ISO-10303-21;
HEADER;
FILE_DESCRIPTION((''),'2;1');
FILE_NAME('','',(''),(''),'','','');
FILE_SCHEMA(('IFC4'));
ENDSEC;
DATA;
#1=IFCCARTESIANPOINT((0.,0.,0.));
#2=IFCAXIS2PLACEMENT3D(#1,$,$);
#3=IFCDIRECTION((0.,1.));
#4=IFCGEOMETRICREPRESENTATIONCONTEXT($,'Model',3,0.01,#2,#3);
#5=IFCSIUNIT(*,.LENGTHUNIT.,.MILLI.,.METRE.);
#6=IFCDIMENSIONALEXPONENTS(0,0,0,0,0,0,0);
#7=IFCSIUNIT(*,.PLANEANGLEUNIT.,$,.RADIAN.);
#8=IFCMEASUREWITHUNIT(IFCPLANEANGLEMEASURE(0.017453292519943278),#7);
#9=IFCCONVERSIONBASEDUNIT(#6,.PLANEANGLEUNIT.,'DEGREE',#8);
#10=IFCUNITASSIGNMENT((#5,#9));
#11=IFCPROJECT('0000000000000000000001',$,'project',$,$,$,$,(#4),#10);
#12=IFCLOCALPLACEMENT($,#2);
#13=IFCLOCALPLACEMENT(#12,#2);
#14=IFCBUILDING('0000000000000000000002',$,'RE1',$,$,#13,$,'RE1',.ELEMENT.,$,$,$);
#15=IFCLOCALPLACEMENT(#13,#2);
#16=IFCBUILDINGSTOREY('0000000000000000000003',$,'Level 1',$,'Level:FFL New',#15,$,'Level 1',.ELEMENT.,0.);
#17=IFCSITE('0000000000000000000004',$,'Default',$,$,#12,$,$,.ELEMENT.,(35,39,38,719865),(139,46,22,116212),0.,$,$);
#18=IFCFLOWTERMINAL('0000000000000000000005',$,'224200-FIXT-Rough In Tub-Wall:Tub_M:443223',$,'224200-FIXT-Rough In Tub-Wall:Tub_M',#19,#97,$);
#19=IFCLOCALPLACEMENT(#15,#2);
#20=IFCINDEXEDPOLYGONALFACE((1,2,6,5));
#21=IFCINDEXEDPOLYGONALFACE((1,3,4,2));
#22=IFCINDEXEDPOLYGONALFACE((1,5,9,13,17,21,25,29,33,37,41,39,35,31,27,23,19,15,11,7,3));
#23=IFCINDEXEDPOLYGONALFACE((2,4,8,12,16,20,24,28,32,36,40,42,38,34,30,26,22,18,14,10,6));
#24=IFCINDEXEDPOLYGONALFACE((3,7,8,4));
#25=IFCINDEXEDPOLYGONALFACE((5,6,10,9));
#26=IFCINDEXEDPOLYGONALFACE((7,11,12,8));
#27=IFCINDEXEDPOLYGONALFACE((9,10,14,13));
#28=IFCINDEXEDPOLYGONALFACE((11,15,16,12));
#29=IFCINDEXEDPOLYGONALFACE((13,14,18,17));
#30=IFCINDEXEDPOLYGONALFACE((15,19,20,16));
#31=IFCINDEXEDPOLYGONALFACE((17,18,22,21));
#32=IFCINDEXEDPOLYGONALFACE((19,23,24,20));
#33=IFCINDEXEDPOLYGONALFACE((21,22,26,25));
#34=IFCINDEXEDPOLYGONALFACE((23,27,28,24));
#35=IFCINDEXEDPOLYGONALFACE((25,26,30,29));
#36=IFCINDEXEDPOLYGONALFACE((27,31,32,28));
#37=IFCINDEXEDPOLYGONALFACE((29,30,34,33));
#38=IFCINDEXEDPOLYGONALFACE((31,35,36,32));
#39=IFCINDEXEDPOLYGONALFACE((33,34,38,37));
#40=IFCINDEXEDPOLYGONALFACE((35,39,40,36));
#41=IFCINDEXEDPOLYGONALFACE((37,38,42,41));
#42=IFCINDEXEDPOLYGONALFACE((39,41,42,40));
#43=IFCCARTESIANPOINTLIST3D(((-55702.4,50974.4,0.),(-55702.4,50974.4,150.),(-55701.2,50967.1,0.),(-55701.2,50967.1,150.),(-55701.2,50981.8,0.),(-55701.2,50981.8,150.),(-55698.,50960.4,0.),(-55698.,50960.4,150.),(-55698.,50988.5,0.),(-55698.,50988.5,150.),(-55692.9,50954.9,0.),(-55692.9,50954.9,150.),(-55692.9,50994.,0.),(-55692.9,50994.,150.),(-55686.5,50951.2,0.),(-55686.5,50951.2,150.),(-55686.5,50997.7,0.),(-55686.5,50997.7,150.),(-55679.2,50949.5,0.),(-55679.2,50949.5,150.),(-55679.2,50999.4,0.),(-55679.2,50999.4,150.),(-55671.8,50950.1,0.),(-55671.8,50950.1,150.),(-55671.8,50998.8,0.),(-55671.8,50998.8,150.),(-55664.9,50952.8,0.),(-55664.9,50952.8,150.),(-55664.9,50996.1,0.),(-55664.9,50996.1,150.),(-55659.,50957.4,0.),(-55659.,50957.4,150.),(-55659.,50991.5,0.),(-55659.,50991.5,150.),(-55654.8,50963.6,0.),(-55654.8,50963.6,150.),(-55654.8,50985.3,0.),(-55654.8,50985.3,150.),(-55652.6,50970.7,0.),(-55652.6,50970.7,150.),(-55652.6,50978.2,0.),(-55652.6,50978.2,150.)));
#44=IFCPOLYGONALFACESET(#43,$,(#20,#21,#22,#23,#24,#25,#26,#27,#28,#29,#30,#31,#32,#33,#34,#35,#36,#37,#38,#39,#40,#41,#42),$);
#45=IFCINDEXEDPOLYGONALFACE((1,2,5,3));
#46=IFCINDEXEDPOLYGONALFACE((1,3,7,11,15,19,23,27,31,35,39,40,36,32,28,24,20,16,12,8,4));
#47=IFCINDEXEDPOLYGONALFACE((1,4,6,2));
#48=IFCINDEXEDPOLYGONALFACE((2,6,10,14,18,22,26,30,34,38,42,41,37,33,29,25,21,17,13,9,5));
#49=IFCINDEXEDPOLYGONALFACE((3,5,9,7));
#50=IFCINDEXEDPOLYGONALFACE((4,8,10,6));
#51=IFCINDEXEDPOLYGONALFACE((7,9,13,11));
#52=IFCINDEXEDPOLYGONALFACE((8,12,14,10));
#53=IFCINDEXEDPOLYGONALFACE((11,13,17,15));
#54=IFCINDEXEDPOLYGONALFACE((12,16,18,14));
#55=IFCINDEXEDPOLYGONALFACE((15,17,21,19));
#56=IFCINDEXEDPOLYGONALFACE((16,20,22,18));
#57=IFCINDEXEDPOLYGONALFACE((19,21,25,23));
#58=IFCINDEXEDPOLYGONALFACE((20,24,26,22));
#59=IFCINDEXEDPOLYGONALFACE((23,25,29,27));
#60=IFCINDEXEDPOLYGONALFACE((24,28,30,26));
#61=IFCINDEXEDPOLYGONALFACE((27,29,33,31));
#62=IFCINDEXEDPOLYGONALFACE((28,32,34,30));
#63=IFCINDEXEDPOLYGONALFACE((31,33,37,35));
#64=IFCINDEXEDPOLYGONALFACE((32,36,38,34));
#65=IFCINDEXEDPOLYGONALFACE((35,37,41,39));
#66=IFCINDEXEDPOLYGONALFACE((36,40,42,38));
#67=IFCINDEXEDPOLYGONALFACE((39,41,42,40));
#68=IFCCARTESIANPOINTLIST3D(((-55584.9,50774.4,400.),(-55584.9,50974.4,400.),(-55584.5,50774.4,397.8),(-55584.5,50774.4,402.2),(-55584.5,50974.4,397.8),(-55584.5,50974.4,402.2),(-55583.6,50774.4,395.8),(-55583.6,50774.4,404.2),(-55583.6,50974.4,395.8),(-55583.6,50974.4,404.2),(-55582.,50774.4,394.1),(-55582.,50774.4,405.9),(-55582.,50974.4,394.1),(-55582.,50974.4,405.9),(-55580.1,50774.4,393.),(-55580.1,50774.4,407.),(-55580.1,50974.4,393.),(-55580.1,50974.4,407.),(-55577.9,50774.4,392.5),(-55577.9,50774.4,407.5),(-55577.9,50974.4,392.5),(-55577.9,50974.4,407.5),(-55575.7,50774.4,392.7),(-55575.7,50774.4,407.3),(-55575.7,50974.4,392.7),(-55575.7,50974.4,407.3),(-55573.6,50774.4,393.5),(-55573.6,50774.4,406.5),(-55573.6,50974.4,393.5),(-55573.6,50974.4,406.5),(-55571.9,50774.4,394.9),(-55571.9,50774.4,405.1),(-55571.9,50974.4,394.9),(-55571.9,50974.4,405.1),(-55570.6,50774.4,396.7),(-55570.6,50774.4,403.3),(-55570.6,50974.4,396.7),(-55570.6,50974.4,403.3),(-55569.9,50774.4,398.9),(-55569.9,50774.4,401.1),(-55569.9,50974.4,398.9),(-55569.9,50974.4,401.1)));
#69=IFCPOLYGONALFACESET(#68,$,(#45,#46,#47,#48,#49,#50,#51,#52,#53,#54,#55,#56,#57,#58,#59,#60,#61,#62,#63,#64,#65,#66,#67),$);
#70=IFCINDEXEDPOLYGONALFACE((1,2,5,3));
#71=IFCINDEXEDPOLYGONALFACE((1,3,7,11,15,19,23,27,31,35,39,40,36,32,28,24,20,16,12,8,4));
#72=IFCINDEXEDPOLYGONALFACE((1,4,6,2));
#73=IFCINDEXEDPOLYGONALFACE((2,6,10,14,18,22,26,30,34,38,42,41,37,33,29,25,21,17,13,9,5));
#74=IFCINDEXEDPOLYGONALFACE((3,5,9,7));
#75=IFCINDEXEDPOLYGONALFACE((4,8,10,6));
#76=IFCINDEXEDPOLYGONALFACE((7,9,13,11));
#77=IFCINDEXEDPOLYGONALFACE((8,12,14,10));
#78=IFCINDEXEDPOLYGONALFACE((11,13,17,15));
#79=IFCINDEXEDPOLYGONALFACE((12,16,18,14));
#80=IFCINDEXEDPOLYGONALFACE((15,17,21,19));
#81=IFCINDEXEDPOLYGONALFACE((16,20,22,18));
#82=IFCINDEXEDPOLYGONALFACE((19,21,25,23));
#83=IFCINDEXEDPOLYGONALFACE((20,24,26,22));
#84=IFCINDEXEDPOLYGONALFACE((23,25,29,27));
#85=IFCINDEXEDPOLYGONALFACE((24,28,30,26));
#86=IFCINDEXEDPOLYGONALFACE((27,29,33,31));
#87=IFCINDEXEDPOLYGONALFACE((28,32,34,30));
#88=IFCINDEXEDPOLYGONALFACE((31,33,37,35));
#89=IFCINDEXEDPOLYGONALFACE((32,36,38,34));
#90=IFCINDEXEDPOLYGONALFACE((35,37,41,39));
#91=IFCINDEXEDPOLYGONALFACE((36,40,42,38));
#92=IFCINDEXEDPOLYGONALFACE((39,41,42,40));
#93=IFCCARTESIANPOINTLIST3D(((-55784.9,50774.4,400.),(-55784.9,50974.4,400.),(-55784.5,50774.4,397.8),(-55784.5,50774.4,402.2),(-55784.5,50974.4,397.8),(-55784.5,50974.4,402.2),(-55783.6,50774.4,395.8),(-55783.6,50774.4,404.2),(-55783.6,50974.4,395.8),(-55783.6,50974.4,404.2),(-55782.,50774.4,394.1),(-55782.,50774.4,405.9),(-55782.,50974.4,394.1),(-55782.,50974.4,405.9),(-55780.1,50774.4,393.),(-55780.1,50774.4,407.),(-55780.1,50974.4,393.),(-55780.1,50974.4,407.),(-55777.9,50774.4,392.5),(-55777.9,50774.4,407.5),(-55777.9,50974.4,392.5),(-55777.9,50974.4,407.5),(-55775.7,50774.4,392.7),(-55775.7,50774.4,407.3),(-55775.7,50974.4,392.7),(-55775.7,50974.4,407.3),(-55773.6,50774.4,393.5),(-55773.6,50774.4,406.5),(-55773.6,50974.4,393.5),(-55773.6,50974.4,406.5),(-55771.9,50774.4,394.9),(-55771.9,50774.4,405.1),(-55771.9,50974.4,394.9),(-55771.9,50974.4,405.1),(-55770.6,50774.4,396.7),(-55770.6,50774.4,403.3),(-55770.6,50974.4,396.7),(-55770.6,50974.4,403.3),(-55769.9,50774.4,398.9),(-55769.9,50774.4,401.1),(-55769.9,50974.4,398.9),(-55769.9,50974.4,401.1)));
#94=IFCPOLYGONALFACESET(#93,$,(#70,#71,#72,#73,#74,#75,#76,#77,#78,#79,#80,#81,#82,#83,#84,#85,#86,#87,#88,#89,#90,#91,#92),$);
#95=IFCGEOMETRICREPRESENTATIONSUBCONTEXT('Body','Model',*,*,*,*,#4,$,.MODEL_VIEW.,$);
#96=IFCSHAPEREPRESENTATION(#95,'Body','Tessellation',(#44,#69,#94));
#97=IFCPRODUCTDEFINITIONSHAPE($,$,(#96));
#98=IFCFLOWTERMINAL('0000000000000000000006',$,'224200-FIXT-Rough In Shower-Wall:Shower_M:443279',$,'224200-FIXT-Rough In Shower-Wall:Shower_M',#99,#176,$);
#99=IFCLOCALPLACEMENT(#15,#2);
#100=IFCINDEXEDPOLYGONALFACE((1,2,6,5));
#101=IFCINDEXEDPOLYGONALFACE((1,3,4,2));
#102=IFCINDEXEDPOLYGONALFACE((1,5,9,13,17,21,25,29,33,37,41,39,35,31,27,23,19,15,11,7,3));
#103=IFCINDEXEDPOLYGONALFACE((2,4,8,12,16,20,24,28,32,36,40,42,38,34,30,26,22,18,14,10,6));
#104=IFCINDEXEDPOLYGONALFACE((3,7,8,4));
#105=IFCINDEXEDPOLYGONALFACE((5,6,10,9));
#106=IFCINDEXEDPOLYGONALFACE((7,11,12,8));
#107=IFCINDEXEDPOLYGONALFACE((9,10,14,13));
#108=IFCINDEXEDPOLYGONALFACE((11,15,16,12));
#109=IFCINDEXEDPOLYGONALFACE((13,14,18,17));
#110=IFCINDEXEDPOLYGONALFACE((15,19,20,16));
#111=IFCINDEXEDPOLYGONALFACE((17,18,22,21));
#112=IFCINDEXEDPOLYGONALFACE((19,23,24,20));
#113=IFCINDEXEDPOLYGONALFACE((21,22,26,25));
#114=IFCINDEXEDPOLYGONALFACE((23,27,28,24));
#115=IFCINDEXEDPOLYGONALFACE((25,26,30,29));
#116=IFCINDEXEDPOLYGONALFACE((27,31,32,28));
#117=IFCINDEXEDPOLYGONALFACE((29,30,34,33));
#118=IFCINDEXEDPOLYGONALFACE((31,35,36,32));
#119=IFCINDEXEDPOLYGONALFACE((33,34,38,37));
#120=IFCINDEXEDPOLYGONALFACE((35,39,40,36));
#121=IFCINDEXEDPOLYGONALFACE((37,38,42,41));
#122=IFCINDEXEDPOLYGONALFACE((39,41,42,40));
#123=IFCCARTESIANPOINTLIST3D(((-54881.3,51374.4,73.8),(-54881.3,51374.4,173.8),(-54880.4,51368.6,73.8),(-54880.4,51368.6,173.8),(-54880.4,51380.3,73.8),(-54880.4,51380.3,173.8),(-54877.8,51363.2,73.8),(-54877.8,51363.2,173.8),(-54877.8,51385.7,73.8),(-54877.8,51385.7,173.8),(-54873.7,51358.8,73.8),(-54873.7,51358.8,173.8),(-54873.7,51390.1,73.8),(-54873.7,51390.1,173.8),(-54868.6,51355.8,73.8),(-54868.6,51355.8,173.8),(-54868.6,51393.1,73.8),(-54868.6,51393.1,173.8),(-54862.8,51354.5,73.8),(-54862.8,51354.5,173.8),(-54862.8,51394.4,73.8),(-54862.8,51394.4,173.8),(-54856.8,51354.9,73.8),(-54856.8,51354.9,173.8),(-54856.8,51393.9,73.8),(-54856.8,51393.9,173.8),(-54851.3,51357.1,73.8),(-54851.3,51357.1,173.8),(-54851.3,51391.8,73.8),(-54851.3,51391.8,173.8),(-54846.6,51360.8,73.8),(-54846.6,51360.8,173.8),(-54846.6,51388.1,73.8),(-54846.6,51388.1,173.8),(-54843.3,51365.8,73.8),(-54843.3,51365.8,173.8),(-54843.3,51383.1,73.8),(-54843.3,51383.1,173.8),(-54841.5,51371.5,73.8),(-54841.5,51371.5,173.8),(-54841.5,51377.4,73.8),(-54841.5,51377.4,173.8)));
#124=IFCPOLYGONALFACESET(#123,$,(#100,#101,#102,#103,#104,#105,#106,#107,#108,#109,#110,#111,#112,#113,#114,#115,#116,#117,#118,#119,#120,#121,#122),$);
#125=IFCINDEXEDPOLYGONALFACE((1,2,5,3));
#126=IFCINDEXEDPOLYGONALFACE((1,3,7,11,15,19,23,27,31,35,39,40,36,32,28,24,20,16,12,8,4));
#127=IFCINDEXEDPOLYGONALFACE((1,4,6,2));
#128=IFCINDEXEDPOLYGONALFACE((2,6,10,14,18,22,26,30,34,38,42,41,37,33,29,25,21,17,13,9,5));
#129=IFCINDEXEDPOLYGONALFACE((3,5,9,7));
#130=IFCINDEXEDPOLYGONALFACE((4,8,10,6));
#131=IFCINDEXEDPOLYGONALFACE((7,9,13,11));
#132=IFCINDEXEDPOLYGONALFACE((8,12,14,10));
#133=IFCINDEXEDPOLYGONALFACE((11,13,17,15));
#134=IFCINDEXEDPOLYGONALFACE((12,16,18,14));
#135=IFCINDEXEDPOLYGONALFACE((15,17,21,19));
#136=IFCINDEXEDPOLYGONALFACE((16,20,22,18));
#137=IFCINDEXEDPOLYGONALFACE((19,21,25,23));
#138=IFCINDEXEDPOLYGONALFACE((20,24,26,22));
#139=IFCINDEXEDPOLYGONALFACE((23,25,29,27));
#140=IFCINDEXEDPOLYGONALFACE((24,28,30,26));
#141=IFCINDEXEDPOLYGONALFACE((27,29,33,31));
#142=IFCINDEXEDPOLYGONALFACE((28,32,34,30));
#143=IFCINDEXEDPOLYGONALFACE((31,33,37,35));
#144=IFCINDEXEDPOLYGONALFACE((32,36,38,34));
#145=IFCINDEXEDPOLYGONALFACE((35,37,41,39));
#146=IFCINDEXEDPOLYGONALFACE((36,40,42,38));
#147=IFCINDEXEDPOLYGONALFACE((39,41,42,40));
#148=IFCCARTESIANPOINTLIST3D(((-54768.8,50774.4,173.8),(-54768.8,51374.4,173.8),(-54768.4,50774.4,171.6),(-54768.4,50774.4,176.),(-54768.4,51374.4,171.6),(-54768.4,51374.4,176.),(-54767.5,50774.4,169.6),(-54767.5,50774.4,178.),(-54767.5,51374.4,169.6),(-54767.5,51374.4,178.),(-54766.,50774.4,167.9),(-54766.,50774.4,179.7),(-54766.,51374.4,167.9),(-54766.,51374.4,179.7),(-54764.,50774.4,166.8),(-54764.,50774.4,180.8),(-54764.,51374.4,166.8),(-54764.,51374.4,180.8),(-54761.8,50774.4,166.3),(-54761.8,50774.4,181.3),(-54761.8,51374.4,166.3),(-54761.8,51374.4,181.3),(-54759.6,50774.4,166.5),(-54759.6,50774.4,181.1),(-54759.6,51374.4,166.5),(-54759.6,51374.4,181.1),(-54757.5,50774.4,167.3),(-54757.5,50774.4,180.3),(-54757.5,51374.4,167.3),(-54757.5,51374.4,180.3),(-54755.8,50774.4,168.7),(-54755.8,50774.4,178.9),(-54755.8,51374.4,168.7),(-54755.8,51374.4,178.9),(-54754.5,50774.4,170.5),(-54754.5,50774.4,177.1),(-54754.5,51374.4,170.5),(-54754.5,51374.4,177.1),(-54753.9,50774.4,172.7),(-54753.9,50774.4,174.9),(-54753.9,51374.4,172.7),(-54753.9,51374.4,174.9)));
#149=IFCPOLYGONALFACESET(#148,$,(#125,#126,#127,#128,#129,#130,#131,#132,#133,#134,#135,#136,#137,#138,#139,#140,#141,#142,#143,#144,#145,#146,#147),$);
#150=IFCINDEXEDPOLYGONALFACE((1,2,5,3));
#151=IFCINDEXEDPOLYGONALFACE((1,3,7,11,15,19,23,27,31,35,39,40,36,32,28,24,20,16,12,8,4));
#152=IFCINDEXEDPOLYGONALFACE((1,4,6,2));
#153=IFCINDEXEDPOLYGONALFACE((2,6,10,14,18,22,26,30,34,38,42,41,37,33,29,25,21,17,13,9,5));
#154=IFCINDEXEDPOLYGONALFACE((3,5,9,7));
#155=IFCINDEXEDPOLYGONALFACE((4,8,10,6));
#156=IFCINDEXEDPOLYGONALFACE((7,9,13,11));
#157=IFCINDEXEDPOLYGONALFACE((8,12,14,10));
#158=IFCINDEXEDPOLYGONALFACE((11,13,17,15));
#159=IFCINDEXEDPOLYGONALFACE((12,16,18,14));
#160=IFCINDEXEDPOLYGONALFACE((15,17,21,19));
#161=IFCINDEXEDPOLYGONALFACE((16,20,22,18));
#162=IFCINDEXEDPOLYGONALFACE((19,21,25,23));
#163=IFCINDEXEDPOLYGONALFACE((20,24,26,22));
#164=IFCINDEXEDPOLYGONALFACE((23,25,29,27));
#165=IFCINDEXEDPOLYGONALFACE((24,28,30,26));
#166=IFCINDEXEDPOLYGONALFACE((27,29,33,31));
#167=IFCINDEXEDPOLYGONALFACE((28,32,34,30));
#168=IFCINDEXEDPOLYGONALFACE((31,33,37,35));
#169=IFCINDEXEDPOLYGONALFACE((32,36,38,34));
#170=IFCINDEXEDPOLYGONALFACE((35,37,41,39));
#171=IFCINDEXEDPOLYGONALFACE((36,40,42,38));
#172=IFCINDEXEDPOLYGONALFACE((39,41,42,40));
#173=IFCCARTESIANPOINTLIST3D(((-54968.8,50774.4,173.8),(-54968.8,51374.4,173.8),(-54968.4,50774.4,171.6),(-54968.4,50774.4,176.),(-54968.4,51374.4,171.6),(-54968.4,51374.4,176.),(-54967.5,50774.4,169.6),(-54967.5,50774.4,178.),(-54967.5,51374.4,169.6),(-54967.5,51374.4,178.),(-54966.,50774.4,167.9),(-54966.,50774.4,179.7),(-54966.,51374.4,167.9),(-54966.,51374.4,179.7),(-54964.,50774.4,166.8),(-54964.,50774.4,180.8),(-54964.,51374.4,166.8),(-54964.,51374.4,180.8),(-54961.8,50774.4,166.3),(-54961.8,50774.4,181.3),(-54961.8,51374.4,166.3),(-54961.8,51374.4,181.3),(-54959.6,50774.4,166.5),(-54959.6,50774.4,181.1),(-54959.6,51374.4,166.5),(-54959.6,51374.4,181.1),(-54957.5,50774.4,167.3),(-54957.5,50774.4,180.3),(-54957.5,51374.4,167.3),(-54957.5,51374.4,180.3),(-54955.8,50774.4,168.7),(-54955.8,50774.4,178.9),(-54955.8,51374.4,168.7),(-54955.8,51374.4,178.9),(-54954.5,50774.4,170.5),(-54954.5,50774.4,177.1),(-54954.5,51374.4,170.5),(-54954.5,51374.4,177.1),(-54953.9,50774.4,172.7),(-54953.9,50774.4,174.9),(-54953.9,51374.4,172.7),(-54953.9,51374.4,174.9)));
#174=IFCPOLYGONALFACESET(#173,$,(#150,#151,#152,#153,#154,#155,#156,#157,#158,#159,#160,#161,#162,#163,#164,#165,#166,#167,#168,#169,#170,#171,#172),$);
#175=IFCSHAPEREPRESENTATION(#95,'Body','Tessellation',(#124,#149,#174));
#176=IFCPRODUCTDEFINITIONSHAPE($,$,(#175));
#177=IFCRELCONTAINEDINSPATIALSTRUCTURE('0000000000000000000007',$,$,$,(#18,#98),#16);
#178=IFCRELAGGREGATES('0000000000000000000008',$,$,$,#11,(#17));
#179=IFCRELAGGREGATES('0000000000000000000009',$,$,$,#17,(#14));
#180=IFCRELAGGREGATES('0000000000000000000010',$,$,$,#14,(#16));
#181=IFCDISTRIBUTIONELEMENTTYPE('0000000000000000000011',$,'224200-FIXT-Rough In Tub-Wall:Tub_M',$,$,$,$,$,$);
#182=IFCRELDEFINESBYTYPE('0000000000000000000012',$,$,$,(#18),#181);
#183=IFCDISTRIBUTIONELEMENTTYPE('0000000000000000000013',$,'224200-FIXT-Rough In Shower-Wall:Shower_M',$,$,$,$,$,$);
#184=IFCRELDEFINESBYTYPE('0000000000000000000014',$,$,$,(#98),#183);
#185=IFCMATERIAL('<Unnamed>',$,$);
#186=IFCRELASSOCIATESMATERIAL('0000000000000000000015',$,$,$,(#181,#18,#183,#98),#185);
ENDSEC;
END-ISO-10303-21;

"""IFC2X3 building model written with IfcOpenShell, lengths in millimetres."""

from ifc_helpers import new_model, entity, si_unit, converted_unit, direction, frame, frame_2d, origin, origin_2d_with_axis, place, context, subcontext, project, spatial, circle, extrude, source, transform, mapped, material, type_object, type_shapes, element, save


model = new_model("IFC2X3")

# Units and contexts
model_context = context("Model", 3, precision=0.01, world=origin(), true_north=direction((0.0, 1.0)))
body_context = subcontext(model_context, "Body", "Model", "MODEL_VIEW")
ifc_project = project(units=[si_unit("LENGTHUNIT", "METRE", prefix="MILLI"), converted_unit("PLANEANGLEUNIT", "DEGREE", entity("IfcPlaneAngleMeasure", 0.017453292519943278), si_unit("PLANEANGLEUNIT", "RADIAN"), dimensions=[0, 0, 0, 0, 0, 0, 0])], contexts=[model_context])

# Site, building, storey
site_placement = place(None, origin())
site = spatial("IfcSite", under=ifc_project, at=site_placement, Name="Default", CompositionType="ELEMENT", RefLatitude=(35, 39, 38, 719865), RefLongitude=(139, 46, 22, 116212), RefElevation=0.0)
building_placement = place(site_placement, origin())
building = spatial("IfcBuilding", under=site, at=building_placement, Name="RE1", LongName="RE1", CompositionType="ELEMENT")
storey_placement = place(building_placement, origin())
storey = spatial("IfcBuildingStorey", under=building, at=storey_placement, Name="Level 1", ObjectType="Level:FFL New", LongName="Level 1", CompositionType="ELEMENT", Elevation=0.0)

# Flow terminals
ifc_material = material(Name="<Unnamed>")
distribution_element_type_1 = type_object("IfcDistributionElementType", Name="224200-FIXT-Rough In Tub-Wall:Tub_M", material=ifc_material)
shared_shape_1 = source(origin(), body_context, "Body", "SweptSolid", [
    extrude(circle(Radius=25.0, at=frame_2d((0.0, 0.0), x_axis=(1.0, 0.0))), frame((0.0, 0.0, 200.0), z_axis=(0.0, 1.0, 0.0), x_axis=(1.0, 0.0, 0.0)), (0.0, 0.0, 1.0), 150.0),
    extrude(circle(Radius=7.5, at=origin_2d_with_axis()), frame((-100.0, 400.0, 0.0)), (0.0, 0.0, 1.0), 200.0),
    extrude(circle(Radius=7.5, at=origin_2d_with_axis()), frame((100.0, 400.0, 0.0)), (0.0, 0.0, 1.0), 200.0),
])
type_shapes(distribution_element_type_1, [shared_shape_1])
flow_terminal_1_placement = place(storey_placement, frame((-55677.4, 50774.4, 0.0), z_axis=(0.0, 1.0, 0.0), x_axis=(-1.0, 0.0, 0.0)))
element("IfcFlowTerminal", 1, at=flow_terminal_1_placement, inside=storey, type_object=distribution_element_type_1, material=ifc_material, Name="224200-FIXT-Rough In Tub-Wall:Tub_M:443223", ObjectType="224200-FIXT-Rough In Tub-Wall:Tub_M", context=body_context, shape_type="MappedRepresentation", body=[
    mapped(shared_shape_1, transform((0.0, 0.0, 0.0), scale=1.0)),
])
distribution_element_type_2 = type_object("IfcDistributionElementType", Name="224200-FIXT-Rough In Shower-Wall:Shower_M", material=ifc_material)
shared_shape_2 = source(origin(), body_context, "Body", "SweptSolid", [
    extrude(circle(Radius=20.0, at=frame_2d((0.0, 0.0), x_axis=(1.0, 0.0))), frame((0.0, -100.0, 600.0), z_axis=(0.0, 1.0, 0.0), x_axis=(1.0, 0.0, 0.0)), (0.0, 0.0, 1.0), 100.0),
    extrude(circle(Radius=7.5, at=frame_2d((0.0, 0.0), x_axis=(1.0, 0.0))), frame((-100.0, 0.0, 0.0)), (0.0, 0.0, 1.0), 600.0),
    extrude(circle(Radius=7.5, at=frame_2d((0.0, 0.0), x_axis=(1.0, 0.0))), frame((100.0, 0.0, 0.0)), (0.0, 0.0, 1.0), 600.0),
])
type_shapes(distribution_element_type_2, [shared_shape_2])
flow_terminal_2_placement = place(storey_placement, frame((-54861.3, 50774.4, 173.8), z_axis=(0.0, 1.0, 0.0), x_axis=(-1.0, 0.0, 0.0)))
element("IfcFlowTerminal", 2, at=flow_terminal_2_placement, inside=storey, type_object=distribution_element_type_2, material=ifc_material, Name="224200-FIXT-Rough In Shower-Wall:Shower_M:443279", ObjectType="224200-FIXT-Rough In Shower-Wall:Shower_M", context=body_context, shape_type="MappedRepresentation", body=[
    mapped(shared_shape_2, transform((0.0, 0.0, 0.0), scale=1.0)),
])

save(model, "model.ifc")
